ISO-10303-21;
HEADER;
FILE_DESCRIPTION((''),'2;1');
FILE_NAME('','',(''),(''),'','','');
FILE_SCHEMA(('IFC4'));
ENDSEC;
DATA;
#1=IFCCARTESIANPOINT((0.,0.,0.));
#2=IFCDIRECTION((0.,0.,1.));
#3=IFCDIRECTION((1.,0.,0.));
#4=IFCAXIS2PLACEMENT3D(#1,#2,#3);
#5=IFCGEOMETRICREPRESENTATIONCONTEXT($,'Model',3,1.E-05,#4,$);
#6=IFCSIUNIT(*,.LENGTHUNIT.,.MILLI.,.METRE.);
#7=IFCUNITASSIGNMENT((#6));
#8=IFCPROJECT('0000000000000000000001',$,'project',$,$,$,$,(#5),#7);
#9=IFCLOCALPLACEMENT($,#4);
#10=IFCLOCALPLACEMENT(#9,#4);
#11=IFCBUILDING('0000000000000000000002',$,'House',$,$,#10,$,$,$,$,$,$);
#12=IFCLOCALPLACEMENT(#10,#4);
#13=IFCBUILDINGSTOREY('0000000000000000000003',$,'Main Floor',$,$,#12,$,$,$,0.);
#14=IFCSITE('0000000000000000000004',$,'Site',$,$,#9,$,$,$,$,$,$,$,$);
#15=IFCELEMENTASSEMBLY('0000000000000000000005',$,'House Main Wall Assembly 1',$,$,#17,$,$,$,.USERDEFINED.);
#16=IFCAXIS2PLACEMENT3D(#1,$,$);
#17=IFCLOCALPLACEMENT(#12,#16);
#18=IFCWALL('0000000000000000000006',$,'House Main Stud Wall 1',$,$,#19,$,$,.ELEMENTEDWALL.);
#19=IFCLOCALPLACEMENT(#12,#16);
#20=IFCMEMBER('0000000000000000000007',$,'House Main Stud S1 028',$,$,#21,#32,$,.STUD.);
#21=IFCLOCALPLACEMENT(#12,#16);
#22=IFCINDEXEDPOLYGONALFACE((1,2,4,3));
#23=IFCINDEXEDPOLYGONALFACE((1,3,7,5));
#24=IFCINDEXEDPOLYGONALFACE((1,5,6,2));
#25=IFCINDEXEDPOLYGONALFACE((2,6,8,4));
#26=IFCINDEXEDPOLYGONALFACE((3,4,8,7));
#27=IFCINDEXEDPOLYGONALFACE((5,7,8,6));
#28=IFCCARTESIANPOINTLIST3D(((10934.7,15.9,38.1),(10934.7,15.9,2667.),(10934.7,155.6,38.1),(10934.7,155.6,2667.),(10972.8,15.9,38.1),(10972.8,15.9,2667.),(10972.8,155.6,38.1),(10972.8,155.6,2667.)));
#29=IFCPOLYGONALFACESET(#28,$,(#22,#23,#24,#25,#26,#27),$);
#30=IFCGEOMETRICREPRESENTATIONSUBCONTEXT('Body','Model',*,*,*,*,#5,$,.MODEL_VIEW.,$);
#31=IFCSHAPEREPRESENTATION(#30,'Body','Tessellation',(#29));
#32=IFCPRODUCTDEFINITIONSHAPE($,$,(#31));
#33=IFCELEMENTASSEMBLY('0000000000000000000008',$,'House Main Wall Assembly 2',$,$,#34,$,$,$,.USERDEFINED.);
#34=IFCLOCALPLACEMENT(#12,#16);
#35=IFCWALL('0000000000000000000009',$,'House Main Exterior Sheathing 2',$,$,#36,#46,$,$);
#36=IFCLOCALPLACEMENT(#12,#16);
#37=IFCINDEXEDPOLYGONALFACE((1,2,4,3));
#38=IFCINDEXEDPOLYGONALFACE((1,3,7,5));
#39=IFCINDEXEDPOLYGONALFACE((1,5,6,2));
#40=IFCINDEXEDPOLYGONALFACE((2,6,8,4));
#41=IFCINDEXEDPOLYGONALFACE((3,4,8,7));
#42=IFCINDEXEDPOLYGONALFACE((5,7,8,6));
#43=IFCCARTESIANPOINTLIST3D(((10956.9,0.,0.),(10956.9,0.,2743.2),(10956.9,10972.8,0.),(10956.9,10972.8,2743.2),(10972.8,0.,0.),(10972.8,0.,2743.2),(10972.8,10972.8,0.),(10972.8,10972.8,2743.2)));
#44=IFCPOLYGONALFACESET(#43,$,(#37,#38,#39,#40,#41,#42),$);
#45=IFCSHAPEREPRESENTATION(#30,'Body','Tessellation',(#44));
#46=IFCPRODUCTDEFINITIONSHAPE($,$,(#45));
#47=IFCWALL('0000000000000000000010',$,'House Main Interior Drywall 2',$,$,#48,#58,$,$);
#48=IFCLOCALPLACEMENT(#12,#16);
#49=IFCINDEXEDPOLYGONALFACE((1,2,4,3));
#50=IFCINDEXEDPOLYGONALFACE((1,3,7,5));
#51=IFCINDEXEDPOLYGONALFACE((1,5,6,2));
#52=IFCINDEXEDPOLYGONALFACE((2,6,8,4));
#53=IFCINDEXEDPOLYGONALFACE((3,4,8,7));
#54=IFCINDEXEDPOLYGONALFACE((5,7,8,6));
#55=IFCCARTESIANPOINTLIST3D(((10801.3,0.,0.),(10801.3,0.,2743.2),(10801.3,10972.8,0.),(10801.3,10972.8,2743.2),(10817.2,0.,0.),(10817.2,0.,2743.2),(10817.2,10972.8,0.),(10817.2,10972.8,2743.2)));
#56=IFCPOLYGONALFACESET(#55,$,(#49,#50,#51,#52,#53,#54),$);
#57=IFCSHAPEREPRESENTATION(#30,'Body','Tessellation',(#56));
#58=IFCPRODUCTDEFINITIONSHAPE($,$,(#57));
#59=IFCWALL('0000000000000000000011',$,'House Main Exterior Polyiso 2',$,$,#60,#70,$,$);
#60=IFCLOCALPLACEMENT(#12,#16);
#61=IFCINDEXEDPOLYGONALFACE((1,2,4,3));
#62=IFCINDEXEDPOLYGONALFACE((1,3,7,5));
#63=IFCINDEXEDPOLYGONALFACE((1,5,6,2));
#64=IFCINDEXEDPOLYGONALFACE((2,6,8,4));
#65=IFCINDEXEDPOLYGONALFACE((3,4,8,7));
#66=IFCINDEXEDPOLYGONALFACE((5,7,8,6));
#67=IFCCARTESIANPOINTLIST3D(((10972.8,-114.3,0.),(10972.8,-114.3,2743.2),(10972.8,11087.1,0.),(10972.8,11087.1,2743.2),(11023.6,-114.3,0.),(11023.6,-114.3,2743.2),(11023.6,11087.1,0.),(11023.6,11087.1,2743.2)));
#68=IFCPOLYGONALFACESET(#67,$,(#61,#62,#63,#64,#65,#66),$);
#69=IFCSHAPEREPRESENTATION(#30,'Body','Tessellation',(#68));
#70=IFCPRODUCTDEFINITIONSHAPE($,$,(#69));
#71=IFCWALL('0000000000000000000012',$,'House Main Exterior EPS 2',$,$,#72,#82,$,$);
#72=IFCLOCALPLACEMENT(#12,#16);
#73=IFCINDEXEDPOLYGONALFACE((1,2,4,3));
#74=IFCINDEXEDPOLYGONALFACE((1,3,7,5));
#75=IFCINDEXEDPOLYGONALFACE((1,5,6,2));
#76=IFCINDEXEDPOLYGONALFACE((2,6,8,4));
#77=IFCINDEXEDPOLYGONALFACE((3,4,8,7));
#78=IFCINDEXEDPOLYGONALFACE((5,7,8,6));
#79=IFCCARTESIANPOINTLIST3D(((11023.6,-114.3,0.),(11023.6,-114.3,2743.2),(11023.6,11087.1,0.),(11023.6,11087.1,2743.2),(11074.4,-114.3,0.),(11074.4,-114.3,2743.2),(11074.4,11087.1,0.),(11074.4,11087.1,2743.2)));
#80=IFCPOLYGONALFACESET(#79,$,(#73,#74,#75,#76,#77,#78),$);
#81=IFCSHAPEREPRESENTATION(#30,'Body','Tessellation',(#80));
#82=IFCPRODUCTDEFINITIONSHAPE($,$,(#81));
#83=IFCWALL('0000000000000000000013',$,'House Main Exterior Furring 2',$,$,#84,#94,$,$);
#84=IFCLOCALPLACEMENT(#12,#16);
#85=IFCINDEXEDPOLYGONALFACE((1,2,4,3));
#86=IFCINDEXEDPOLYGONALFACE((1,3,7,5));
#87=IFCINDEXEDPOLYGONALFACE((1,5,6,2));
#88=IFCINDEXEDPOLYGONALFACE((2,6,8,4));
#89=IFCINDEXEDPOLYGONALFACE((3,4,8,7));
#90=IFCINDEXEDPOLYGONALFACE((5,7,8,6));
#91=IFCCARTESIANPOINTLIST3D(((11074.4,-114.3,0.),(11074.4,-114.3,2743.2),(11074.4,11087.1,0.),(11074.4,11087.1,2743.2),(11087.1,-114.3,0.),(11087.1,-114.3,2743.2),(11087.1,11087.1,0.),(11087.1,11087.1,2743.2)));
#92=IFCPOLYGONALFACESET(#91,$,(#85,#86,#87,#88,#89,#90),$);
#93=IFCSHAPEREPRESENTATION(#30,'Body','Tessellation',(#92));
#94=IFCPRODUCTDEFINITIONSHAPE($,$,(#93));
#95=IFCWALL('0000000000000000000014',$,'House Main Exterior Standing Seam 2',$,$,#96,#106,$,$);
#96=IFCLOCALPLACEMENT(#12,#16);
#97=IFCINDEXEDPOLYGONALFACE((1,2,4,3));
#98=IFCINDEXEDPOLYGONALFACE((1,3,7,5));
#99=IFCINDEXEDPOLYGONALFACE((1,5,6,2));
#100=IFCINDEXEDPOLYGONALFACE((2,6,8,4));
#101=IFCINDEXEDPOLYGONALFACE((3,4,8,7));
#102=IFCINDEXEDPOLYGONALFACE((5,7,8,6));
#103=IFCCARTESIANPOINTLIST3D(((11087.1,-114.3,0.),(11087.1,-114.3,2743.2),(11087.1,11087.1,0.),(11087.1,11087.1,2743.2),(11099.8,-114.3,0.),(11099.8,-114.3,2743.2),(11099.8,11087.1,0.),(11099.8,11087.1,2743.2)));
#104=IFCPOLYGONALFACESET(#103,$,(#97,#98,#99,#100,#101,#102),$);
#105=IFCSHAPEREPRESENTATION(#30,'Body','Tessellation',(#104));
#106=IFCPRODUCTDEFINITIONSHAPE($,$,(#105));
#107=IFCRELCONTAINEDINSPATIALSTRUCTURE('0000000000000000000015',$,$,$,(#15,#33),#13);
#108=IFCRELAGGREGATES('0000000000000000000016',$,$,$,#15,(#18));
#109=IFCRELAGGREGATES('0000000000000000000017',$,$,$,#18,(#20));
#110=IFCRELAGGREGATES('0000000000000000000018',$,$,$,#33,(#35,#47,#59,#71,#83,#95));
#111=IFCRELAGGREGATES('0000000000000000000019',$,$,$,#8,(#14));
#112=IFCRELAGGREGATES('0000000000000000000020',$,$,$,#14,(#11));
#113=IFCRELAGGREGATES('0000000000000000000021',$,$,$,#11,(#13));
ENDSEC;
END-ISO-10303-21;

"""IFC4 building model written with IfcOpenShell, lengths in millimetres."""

from ifc_helpers import new_model, si_unit, frame, origin_with_axes, origin_2d, place, context, subcontext, project, spatial, indexed_curve, rectangle, outline, extrude, element, aggregate, save


model = new_model("IFC4")

# Units and contexts
model_context = context("Model", 3, precision=1e-05, world=origin_with_axes())
body_context = subcontext(model_context, "Body", "Model", "MODEL_VIEW")
ifc_project = project(units=[si_unit("LENGTHUNIT", "METRE", prefix="MILLI")], contexts=[model_context])

# Site, building, storey
site_placement = place(None, origin_with_axes())
site = spatial("IfcSite", under=ifc_project, at=site_placement, Name="Site")
building_placement = place(site_placement, origin_with_axes())
building = spatial("IfcBuilding", under=site, at=building_placement, Name="House")
storey_placement = place(building_placement, origin_with_axes())
storey = spatial("IfcBuildingStorey", under=building, at=storey_placement, Name="Main Floor", Elevation=0.0)

# Element assembly, wall, member
assembly_1_placement = place(storey_placement, origin_with_axes())
assembly_1 = element("IfcElementAssembly", 1, at=assembly_1_placement, inside=storey, Name="House Main Wall Assembly 1", PredefinedType="USERDEFINED")
wall_1_placement = place(assembly_1_placement, origin_with_axes())
wall_1 = element("IfcWall", 2, at=wall_1_placement, Name="House Main Stud Wall 1", PredefinedType="ELEMENTEDWALL")
aggregate(assembly_1, [wall_1])
member_1_placement = place(wall_1_placement, frame((10953.8, 85.7, 38.1), z_axis=(0.0, 0.0, 1.0), x_axis=(1.0, 0.0, 0.0)))
member_1 = element("IfcMember", 3, at=member_1_placement, Name="House Main Stud S1 028", PredefinedType="STUD", context=body_context, shape_type="SweptSolid", body=[
    extrude(rectangle(XDim=38.1, YDim=139.7, at=origin_2d()), origin_with_axes(), (0.0, 0.0, 1.0), 2628.9),
])
aggregate(wall_1, [member_1])

# Element assembly, walls
assembly_2_placement = place(storey_placement, origin_with_axes())
assembly_2 = element("IfcElementAssembly", 4, at=assembly_2_placement, inside=storey, Name="House Main Wall Assembly 2", PredefinedType="USERDEFINED")
wall_2_placement = place(assembly_2_placement, frame((10972.8, 0.0, 0.0), z_axis=(0.0, 0.0, 1.0), x_axis=(0.0, 1.0, 0.0)))
wall_2 = element("IfcWall", 5, at=wall_2_placement, Name="House Main Exterior Sheathing 2", context=body_context, shape_type="SweptSolid", body=[
    extrude(outline(indexed_curve([(0.0, 0.0), (0.0, 15.9), (10972.8, 15.9), (10972.8, 0.0), (0.0, 0.0)], self_intersect=False)), origin_with_axes(), (0.0, 0.0, 1.0), 2743.2),
])
wall_3_placement = place(assembly_2_placement, frame((10972.8, 0.0, 0.0), z_axis=(0.0, 0.0, 1.0), x_axis=(0.0, 1.0, 0.0)))
wall_3 = element("IfcWall", 6, at=wall_3_placement, Name="House Main Interior Drywall 2", context=body_context, shape_type="SweptSolid", body=[
    extrude(outline(indexed_curve([(0.0, 0.0), (0.0, 15.9), (10972.8, 15.9), (10972.8, 0.0), (0.0, 0.0)], self_intersect=False)), frame((0.0, 155.6, 0.0), z_axis=(0.0, 0.0, 1.0), x_axis=(1.0, 0.0, 0.0)), (0.0, 0.0, 1.0), 2743.2),
])
wall_4_placement = place(assembly_2_placement, frame((10972.8, -114.3, 0.0), z_axis=(0.0, 0.0, 1.0), x_axis=(0.0, 1.0, 0.0)))
wall_4 = element("IfcWall", 7, at=wall_4_placement, Name="House Main Exterior Polyiso 2", context=body_context, shape_type="SweptSolid", body=[
    extrude(outline(indexed_curve([(0.0, 0.0), (0.0, -50.8), (11201.4, -50.8), (11201.4, 0.0), (0.0, 0.0)], self_intersect=False)), origin_with_axes(), (0.0, 0.0, 1.0), 2743.2),
])
wall_5_placement = place(assembly_2_placement, frame((10972.8, -114.3, 0.0), z_axis=(0.0, 0.0, 1.0), x_axis=(0.0, 1.0, 0.0)))
wall_5 = element("IfcWall", 8, at=wall_5_placement, Name="House Main Exterior EPS 2", context=body_context, shape_type="SweptSolid", body=[
    extrude(outline(indexed_curve([(0.0, 0.0), (0.0, -50.8), (11201.4, -50.8), (11201.4, 0.0), (0.0, 0.0)], self_intersect=False)), frame((0.0, -50.8, 0.0), z_axis=(0.0, 0.0, 1.0), x_axis=(1.0, 0.0, 0.0)), (0.0, 0.0, 1.0), 2743.2),
])
wall_6_placement = place(assembly_2_placement, frame((10972.8, -114.3, 0.0), z_axis=(0.0, 0.0, 1.0), x_axis=(0.0, 1.0, 0.0)))
wall_6 = element("IfcWall", 9, at=wall_6_placement, Name="House Main Exterior Furring 2", context=body_context, shape_type="SweptSolid", body=[
    extrude(outline(indexed_curve([(0.0, 0.0), (0.0, -12.7), (11201.4, -12.7), (11201.4, 0.0), (0.0, 0.0)], self_intersect=False)), frame((0.0, -101.6, 0.0), z_axis=(0.0, 0.0, 1.0), x_axis=(1.0, 0.0, 0.0)), (0.0, 0.0, 1.0), 2743.2),
])
wall_7_placement = place(assembly_2_placement, frame((10972.8, -114.3, 0.0), z_axis=(0.0, 0.0, 1.0), x_axis=(0.0, 1.0, 0.0)))
wall_7 = element("IfcWall", 10, at=wall_7_placement, Name="House Main Exterior Standing Seam 2", context=body_context, shape_type="SweptSolid", body=[
    extrude(outline(indexed_curve([(0.0, 0.0), (0.0, -12.7), (11201.4, -12.7), (11201.4, 0.0), (0.0, 0.0)], self_intersect=False)), frame((0.0, -114.3, 0.0), z_axis=(0.0, 0.0, 1.0), x_axis=(1.0, 0.0, 0.0)), (0.0, 0.0, 1.0), 2743.2),
])
aggregate(assembly_2, [wall_2, wall_3, wall_4, wall_5, wall_6, wall_7])

save(model, "model.ifc")
